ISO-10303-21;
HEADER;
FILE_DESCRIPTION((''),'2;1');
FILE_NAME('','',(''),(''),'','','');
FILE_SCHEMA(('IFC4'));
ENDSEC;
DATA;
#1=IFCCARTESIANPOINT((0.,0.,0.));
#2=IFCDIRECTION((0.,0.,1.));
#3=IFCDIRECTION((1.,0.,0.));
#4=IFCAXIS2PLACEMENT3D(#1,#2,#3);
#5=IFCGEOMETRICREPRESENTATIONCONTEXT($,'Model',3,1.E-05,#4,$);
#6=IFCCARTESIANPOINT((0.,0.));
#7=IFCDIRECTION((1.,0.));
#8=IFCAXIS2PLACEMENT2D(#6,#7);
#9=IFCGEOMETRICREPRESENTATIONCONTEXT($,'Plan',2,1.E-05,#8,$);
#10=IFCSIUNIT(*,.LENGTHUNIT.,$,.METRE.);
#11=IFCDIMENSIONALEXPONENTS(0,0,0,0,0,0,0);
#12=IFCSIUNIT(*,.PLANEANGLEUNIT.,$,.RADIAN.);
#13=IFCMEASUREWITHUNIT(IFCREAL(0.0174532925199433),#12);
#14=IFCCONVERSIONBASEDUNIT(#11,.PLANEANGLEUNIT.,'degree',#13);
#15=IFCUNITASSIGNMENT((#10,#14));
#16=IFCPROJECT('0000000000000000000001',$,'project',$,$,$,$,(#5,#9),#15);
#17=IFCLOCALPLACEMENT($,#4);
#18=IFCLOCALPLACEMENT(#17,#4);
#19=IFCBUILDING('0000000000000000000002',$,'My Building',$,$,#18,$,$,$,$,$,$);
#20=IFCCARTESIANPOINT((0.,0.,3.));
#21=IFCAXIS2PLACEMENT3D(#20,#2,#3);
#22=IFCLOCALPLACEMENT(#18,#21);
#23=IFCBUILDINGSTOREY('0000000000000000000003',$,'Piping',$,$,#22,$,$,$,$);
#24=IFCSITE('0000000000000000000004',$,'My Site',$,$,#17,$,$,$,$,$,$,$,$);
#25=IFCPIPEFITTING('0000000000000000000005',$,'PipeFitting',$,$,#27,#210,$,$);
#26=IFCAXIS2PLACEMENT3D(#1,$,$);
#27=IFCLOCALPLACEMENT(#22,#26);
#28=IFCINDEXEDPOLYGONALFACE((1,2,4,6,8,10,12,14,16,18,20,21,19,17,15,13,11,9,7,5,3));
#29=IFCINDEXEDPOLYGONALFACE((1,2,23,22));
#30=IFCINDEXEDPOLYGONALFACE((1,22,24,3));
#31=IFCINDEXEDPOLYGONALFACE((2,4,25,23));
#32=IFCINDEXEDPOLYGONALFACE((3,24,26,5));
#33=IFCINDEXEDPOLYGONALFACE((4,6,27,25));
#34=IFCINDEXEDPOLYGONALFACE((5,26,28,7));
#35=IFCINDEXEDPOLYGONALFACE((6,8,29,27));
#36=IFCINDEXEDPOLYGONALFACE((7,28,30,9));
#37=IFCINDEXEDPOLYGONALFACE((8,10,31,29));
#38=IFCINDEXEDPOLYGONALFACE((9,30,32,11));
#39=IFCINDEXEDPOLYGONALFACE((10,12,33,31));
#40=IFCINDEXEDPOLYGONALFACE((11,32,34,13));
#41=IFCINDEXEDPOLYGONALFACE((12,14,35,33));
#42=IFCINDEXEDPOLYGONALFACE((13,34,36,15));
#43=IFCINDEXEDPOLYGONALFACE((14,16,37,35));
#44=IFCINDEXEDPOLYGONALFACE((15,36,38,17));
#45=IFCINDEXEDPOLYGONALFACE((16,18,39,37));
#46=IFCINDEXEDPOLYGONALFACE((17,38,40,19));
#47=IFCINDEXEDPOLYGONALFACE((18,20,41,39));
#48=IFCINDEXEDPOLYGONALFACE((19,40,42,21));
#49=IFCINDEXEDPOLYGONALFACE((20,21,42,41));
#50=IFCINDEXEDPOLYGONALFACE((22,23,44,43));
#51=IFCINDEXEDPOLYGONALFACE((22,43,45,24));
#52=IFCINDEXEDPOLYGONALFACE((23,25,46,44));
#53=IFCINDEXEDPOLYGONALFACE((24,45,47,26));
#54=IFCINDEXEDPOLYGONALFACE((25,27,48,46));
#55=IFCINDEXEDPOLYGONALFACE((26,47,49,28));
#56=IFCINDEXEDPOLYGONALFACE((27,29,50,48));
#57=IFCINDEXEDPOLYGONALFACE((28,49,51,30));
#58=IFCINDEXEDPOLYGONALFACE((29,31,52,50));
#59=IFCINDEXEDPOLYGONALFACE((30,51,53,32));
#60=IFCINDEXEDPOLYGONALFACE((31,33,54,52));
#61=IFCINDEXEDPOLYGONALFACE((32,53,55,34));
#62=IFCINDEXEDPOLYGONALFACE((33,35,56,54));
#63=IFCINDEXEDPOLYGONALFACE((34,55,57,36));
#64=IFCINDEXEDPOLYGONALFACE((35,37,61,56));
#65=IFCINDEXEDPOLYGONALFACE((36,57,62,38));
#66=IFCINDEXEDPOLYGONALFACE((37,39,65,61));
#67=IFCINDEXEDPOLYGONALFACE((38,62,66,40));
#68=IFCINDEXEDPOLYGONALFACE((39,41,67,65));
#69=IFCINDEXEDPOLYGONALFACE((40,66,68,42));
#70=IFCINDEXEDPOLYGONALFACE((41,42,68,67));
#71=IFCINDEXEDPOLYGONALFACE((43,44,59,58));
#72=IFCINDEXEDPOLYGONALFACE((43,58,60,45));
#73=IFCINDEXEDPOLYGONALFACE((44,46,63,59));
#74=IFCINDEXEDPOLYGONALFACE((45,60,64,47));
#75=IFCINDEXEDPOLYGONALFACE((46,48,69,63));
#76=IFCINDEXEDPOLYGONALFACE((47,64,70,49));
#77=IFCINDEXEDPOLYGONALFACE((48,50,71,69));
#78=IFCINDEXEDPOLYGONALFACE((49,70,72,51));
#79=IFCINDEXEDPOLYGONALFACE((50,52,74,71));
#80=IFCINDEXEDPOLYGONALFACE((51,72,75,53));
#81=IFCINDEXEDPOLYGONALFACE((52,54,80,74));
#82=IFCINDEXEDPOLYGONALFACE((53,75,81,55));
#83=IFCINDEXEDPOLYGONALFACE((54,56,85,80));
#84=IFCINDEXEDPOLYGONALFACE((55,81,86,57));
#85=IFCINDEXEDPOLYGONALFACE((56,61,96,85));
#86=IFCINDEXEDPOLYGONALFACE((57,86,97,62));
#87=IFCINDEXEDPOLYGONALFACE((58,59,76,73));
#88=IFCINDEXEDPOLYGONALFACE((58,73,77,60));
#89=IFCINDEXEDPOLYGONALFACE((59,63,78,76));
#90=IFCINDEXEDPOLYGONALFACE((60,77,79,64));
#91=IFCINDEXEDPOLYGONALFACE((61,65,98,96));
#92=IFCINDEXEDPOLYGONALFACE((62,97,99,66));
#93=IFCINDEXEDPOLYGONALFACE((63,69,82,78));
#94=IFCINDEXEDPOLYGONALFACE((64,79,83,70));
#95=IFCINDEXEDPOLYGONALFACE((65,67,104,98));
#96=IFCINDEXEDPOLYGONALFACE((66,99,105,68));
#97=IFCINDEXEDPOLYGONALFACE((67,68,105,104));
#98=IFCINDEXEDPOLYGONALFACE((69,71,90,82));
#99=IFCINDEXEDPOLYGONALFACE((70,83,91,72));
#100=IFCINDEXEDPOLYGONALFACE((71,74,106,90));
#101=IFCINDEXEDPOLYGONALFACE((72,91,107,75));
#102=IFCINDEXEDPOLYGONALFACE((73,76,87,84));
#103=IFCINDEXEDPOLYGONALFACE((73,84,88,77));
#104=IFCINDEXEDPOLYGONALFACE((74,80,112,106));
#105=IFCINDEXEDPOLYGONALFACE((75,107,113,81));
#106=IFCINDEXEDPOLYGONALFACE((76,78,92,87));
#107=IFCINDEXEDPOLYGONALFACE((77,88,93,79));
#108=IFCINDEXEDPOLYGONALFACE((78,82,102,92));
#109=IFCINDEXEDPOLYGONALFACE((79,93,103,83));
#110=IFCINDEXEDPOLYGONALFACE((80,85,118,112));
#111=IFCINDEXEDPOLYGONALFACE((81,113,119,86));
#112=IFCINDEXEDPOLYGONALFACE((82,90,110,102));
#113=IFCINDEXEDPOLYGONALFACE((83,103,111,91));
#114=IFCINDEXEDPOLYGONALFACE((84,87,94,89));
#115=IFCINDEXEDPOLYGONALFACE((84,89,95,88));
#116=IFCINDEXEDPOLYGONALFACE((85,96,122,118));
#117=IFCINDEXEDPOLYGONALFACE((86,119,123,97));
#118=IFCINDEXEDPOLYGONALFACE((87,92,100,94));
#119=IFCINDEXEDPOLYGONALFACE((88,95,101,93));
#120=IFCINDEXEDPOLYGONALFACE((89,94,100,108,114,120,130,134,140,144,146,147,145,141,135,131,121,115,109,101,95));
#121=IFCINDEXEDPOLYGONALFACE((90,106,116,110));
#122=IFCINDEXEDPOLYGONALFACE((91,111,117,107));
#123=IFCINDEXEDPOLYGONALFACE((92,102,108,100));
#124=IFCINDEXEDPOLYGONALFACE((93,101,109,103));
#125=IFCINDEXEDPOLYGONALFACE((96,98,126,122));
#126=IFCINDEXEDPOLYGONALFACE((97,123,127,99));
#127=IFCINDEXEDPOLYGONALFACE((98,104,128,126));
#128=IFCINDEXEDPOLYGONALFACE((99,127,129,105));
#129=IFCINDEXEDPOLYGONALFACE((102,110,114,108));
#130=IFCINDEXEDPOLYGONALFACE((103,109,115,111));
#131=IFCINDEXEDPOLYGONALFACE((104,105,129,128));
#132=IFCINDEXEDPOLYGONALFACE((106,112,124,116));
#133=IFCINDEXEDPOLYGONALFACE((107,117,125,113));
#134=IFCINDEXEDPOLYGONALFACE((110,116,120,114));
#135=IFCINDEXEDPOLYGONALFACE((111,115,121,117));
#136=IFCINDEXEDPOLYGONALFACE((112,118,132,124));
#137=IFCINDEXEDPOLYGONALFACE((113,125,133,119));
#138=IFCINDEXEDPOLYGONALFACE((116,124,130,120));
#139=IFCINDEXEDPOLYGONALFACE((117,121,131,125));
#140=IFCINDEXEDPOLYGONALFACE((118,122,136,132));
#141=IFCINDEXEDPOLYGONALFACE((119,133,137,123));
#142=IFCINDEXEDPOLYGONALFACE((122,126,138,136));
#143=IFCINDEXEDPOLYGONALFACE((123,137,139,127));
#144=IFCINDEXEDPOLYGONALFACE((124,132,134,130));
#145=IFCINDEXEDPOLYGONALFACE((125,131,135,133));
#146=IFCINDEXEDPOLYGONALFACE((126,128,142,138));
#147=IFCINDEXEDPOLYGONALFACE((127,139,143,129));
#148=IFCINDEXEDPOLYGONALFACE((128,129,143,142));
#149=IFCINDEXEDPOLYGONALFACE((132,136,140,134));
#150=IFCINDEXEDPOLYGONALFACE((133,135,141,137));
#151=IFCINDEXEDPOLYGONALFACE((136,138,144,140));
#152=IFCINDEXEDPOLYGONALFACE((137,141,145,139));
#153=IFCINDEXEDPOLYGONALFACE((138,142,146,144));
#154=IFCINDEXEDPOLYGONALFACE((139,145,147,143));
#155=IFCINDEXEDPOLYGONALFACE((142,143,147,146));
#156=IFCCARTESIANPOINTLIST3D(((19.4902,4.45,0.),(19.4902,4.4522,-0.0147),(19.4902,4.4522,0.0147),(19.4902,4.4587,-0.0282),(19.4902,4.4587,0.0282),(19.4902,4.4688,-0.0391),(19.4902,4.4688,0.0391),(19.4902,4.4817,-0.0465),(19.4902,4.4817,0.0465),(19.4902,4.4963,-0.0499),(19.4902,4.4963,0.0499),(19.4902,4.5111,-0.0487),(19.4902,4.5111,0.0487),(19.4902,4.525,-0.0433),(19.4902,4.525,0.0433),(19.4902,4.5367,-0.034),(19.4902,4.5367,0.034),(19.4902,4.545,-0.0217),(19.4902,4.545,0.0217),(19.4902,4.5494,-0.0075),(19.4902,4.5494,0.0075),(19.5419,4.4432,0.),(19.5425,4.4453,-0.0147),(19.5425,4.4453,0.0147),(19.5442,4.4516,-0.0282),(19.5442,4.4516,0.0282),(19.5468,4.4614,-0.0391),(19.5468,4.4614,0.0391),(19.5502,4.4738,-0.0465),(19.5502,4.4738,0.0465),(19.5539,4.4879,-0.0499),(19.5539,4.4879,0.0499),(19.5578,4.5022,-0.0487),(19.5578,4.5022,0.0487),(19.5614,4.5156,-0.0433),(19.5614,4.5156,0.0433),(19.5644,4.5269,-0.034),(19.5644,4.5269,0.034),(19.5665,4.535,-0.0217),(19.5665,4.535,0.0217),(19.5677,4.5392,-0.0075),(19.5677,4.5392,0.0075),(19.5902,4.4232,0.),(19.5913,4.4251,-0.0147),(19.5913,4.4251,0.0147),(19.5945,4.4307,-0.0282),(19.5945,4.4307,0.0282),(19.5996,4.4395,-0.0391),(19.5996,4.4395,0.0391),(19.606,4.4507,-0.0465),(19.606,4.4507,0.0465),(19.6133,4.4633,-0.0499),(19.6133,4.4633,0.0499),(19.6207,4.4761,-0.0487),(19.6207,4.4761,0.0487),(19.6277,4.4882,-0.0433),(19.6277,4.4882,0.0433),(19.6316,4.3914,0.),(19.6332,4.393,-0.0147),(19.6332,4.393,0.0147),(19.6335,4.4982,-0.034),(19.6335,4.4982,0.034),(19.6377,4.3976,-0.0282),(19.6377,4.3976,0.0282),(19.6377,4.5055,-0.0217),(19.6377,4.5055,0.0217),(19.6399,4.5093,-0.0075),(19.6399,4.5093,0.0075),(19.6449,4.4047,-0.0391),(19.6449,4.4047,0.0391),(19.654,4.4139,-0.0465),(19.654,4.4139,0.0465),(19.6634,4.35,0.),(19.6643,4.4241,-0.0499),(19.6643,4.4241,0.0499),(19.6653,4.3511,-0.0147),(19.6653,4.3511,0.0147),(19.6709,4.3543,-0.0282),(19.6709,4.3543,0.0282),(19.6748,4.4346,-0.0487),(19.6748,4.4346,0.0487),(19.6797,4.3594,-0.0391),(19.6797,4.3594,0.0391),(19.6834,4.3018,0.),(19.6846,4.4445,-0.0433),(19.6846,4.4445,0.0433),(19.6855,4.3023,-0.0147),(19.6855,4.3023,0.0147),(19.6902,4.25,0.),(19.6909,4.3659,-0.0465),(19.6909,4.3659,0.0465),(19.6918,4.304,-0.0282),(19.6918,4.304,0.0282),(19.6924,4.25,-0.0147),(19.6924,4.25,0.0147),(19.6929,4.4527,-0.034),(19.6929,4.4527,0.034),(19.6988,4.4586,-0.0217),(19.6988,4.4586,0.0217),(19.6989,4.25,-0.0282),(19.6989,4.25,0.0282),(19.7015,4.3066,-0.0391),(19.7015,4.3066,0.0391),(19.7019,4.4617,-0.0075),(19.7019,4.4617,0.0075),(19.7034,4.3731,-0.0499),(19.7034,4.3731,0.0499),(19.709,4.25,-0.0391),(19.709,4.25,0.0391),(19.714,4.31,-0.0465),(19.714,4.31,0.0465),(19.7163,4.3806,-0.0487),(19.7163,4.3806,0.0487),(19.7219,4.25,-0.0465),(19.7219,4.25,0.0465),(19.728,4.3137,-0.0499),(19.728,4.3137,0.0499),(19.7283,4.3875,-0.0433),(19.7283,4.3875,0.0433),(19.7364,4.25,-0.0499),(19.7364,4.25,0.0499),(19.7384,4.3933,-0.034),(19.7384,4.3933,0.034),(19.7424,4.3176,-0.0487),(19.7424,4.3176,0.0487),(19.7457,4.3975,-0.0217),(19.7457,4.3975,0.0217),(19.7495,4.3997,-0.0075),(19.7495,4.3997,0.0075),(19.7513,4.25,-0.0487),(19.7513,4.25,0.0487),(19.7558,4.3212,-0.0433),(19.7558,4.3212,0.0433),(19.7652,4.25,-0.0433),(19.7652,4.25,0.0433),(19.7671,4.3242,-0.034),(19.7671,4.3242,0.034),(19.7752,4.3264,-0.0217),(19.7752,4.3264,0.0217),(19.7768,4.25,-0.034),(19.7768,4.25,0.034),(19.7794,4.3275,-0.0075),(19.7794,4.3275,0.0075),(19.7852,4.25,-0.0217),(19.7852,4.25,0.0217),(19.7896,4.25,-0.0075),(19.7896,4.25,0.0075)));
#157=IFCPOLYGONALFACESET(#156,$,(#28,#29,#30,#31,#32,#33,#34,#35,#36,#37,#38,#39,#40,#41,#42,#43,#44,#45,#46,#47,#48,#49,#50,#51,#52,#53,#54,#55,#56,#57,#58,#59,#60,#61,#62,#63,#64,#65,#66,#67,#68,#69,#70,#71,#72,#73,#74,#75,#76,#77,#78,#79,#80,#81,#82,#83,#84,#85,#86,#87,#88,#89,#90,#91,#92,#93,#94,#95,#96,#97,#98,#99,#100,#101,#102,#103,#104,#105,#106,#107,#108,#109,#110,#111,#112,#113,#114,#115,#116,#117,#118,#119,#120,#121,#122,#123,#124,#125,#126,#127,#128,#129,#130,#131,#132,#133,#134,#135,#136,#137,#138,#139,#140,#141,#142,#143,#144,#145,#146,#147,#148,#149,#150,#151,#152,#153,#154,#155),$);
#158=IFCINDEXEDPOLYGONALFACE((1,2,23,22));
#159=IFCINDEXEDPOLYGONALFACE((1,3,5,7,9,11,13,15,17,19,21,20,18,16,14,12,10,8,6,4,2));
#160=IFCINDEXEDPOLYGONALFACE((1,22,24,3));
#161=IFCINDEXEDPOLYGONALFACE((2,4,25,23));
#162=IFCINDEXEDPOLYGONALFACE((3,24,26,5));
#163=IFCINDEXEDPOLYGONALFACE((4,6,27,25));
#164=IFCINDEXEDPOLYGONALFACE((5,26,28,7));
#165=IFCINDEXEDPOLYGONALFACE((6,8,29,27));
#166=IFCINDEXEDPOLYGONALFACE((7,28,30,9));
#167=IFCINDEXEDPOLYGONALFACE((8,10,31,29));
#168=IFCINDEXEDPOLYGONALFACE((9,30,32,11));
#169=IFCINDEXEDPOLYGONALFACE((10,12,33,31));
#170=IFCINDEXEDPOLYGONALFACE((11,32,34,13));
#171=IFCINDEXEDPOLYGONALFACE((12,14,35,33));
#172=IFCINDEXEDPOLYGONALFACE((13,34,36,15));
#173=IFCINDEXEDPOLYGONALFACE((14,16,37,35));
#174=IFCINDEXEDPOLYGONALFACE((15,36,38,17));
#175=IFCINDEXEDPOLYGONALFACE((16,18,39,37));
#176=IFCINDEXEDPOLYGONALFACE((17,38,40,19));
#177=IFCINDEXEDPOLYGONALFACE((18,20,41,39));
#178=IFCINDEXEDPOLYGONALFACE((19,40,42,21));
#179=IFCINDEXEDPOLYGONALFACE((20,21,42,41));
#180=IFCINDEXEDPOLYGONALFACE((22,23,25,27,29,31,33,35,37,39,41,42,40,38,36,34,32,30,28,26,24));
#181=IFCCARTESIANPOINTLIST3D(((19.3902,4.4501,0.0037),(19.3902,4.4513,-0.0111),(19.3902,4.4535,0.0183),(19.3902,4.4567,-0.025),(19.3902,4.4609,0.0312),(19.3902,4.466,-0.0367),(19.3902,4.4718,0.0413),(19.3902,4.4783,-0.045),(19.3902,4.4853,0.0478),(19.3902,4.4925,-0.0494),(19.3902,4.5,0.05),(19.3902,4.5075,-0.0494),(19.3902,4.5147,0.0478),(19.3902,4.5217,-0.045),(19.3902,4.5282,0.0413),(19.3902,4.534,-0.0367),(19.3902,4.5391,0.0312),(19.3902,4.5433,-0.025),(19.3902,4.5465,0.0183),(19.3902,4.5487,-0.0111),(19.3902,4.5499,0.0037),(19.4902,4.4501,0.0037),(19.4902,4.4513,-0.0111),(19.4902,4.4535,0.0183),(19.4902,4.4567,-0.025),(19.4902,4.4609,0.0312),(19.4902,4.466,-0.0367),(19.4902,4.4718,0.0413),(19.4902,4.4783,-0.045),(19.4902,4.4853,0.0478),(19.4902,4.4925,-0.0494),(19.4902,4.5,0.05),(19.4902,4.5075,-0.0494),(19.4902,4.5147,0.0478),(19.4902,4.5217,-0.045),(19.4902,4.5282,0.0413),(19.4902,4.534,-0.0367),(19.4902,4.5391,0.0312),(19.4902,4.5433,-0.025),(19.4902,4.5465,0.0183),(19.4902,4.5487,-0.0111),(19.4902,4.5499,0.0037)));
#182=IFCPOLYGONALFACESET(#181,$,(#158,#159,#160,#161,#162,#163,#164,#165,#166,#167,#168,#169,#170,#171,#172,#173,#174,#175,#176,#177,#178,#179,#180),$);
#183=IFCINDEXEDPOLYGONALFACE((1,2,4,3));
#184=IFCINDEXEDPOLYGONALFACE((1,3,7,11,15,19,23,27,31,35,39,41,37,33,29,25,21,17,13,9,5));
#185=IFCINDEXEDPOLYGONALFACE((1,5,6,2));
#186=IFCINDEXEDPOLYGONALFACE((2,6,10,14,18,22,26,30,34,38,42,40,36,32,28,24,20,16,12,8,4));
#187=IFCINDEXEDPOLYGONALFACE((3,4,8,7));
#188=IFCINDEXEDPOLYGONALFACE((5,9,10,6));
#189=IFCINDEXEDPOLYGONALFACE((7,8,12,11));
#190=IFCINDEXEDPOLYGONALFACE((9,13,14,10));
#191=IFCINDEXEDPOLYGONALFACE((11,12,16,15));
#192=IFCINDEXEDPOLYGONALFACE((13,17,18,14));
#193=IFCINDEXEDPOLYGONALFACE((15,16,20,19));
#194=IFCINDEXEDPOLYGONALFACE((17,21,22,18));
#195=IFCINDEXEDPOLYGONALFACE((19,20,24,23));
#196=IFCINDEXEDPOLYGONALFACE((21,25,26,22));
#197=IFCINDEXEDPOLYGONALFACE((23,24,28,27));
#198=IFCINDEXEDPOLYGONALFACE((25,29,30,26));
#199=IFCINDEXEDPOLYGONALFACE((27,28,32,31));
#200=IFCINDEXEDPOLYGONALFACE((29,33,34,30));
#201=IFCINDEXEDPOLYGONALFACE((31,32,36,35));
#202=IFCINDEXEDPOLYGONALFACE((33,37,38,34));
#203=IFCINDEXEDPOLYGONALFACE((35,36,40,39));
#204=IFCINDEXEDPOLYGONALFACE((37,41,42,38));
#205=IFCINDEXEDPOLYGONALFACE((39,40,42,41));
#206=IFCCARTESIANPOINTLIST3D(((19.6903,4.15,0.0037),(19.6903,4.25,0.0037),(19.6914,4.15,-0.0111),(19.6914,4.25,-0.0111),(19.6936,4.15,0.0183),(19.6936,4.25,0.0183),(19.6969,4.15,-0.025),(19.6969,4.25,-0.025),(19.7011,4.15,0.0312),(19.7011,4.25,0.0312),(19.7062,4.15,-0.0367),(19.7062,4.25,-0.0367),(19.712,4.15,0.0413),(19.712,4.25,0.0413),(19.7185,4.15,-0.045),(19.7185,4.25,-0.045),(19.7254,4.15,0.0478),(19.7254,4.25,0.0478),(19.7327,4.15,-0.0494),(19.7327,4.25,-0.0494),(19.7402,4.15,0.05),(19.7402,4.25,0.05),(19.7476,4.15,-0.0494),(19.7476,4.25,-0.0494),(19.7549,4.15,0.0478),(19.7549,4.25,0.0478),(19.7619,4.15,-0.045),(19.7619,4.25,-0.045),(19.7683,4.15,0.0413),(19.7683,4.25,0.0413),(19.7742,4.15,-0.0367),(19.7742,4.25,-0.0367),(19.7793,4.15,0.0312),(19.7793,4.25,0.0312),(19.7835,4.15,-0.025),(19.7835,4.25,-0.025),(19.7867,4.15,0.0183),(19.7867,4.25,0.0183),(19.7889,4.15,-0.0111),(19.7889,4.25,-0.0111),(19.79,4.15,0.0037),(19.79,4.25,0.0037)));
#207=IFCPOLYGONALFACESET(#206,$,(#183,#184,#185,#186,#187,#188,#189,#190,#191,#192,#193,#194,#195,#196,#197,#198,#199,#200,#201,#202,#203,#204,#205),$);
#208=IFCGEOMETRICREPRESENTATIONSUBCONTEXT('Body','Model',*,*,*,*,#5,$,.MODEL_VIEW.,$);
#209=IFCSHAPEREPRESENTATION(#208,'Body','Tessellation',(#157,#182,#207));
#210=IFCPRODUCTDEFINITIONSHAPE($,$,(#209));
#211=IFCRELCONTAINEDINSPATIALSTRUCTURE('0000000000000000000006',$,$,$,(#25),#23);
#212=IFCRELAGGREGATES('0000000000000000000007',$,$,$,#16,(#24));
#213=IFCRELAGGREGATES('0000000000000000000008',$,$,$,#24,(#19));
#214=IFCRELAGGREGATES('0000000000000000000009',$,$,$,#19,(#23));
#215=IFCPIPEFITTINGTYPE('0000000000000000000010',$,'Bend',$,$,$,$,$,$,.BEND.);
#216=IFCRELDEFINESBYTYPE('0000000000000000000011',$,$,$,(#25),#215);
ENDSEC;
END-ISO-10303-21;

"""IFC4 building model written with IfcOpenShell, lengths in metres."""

from ifc_helpers import new_model, entity, si_unit, converted_unit, frame, origin_with_axes, origin_2d_with_axis, place, context, subcontext, project, spatial, circle, extrude, source, transform, mapped, type_object, type_shapes, element, save


model = new_model("IFC4")

# Units and contexts
model_context = context("Model", 3, precision=1e-05, world=origin_with_axes())
plan_context = context("Plan", 2, precision=1e-05, world=origin_2d_with_axis())
body_context = subcontext(model_context, "Body", "Model", "MODEL_VIEW")
ifc_project = project(units=[si_unit("LENGTHUNIT", "METRE"), converted_unit("PLANEANGLEUNIT", "degree", entity("IfcReal", 0.0174532925199433), si_unit("PLANEANGLEUNIT", "RADIAN"), dimensions=[0, 0, 0, 0, 0, 0, 0])], contexts=[model_context, plan_context])

# Site, building, storey
site_placement = place(None, origin_with_axes())
site = spatial("IfcSite", under=ifc_project, at=site_placement, Name="My Site")
building_placement = place(site_placement, origin_with_axes())
building = spatial("IfcBuilding", under=site, at=building_placement, Name="My Building")
storey_placement = place(building_placement, frame((0.0, 0.0, 3.0), z_axis=(0.0, 0.0, 1.0), x_axis=(1.0, 0.0, 0.0)))
storey = spatial("IfcBuildingStorey", under=building, at=storey_placement, Name="Piping")

# Pipe fitting
pipe_fitting_type = type_object("IfcPipeFittingType", Name="Bend", PredefinedType="BEND")
shared_shape = source(origin_with_axes(), body_context, "Body", "SolidModel", [
    entity("IfcSweptDiskSolid", entity("IfcIndexedPolyCurve", entity("IfcCartesianPointList3D", [[0.0, 0.0, -0.1], [0.0, -0.0732, -0.2768], [0.0, -0.25, -0.35]]), [entity("IfcArcIndex", [1, 2, 3])]), 0.05),
    extrude(circle(Radius=0.05), origin_with_axes(), (0.0, 0.0, -1.0), 0.1),
    extrude(circle(Radius=0.05), frame((0.0, -0.25, -0.35), z_axis=(0.0, -1.0, 0.0), x_axis=(1.0, 0.0, 0.0)), (0.0, 0.0, 1.0), 0.1),
])
type_shapes(pipe_fitting_type, [shared_shape])
for number, where, z_axis, x_axis, name in (
    (1, (19.3902, 4.5, 0.0), (-1.0, 0.0, 0.0), (0.0, 0.0, 1.0), "PipeFitting"),
):
    element("IfcPipeFitting", number, at=place(storey_placement, frame(where, z_axis=z_axis, x_axis=x_axis)), inside=storey, type_object=pipe_fitting_type, Name=name, context=body_context, shape_type="MappedRepresentation", body=[
        mapped(shared_shape, transform((0.0, 0.0, 0.0), x_axis=(1.0, 0.0, 0.0), y_axis=(0.0, 1.0, 0.0), z_axis=(0.0, 0.0, 1.0), scale=1.0)),
    ])

save(model, "model.ifc")
